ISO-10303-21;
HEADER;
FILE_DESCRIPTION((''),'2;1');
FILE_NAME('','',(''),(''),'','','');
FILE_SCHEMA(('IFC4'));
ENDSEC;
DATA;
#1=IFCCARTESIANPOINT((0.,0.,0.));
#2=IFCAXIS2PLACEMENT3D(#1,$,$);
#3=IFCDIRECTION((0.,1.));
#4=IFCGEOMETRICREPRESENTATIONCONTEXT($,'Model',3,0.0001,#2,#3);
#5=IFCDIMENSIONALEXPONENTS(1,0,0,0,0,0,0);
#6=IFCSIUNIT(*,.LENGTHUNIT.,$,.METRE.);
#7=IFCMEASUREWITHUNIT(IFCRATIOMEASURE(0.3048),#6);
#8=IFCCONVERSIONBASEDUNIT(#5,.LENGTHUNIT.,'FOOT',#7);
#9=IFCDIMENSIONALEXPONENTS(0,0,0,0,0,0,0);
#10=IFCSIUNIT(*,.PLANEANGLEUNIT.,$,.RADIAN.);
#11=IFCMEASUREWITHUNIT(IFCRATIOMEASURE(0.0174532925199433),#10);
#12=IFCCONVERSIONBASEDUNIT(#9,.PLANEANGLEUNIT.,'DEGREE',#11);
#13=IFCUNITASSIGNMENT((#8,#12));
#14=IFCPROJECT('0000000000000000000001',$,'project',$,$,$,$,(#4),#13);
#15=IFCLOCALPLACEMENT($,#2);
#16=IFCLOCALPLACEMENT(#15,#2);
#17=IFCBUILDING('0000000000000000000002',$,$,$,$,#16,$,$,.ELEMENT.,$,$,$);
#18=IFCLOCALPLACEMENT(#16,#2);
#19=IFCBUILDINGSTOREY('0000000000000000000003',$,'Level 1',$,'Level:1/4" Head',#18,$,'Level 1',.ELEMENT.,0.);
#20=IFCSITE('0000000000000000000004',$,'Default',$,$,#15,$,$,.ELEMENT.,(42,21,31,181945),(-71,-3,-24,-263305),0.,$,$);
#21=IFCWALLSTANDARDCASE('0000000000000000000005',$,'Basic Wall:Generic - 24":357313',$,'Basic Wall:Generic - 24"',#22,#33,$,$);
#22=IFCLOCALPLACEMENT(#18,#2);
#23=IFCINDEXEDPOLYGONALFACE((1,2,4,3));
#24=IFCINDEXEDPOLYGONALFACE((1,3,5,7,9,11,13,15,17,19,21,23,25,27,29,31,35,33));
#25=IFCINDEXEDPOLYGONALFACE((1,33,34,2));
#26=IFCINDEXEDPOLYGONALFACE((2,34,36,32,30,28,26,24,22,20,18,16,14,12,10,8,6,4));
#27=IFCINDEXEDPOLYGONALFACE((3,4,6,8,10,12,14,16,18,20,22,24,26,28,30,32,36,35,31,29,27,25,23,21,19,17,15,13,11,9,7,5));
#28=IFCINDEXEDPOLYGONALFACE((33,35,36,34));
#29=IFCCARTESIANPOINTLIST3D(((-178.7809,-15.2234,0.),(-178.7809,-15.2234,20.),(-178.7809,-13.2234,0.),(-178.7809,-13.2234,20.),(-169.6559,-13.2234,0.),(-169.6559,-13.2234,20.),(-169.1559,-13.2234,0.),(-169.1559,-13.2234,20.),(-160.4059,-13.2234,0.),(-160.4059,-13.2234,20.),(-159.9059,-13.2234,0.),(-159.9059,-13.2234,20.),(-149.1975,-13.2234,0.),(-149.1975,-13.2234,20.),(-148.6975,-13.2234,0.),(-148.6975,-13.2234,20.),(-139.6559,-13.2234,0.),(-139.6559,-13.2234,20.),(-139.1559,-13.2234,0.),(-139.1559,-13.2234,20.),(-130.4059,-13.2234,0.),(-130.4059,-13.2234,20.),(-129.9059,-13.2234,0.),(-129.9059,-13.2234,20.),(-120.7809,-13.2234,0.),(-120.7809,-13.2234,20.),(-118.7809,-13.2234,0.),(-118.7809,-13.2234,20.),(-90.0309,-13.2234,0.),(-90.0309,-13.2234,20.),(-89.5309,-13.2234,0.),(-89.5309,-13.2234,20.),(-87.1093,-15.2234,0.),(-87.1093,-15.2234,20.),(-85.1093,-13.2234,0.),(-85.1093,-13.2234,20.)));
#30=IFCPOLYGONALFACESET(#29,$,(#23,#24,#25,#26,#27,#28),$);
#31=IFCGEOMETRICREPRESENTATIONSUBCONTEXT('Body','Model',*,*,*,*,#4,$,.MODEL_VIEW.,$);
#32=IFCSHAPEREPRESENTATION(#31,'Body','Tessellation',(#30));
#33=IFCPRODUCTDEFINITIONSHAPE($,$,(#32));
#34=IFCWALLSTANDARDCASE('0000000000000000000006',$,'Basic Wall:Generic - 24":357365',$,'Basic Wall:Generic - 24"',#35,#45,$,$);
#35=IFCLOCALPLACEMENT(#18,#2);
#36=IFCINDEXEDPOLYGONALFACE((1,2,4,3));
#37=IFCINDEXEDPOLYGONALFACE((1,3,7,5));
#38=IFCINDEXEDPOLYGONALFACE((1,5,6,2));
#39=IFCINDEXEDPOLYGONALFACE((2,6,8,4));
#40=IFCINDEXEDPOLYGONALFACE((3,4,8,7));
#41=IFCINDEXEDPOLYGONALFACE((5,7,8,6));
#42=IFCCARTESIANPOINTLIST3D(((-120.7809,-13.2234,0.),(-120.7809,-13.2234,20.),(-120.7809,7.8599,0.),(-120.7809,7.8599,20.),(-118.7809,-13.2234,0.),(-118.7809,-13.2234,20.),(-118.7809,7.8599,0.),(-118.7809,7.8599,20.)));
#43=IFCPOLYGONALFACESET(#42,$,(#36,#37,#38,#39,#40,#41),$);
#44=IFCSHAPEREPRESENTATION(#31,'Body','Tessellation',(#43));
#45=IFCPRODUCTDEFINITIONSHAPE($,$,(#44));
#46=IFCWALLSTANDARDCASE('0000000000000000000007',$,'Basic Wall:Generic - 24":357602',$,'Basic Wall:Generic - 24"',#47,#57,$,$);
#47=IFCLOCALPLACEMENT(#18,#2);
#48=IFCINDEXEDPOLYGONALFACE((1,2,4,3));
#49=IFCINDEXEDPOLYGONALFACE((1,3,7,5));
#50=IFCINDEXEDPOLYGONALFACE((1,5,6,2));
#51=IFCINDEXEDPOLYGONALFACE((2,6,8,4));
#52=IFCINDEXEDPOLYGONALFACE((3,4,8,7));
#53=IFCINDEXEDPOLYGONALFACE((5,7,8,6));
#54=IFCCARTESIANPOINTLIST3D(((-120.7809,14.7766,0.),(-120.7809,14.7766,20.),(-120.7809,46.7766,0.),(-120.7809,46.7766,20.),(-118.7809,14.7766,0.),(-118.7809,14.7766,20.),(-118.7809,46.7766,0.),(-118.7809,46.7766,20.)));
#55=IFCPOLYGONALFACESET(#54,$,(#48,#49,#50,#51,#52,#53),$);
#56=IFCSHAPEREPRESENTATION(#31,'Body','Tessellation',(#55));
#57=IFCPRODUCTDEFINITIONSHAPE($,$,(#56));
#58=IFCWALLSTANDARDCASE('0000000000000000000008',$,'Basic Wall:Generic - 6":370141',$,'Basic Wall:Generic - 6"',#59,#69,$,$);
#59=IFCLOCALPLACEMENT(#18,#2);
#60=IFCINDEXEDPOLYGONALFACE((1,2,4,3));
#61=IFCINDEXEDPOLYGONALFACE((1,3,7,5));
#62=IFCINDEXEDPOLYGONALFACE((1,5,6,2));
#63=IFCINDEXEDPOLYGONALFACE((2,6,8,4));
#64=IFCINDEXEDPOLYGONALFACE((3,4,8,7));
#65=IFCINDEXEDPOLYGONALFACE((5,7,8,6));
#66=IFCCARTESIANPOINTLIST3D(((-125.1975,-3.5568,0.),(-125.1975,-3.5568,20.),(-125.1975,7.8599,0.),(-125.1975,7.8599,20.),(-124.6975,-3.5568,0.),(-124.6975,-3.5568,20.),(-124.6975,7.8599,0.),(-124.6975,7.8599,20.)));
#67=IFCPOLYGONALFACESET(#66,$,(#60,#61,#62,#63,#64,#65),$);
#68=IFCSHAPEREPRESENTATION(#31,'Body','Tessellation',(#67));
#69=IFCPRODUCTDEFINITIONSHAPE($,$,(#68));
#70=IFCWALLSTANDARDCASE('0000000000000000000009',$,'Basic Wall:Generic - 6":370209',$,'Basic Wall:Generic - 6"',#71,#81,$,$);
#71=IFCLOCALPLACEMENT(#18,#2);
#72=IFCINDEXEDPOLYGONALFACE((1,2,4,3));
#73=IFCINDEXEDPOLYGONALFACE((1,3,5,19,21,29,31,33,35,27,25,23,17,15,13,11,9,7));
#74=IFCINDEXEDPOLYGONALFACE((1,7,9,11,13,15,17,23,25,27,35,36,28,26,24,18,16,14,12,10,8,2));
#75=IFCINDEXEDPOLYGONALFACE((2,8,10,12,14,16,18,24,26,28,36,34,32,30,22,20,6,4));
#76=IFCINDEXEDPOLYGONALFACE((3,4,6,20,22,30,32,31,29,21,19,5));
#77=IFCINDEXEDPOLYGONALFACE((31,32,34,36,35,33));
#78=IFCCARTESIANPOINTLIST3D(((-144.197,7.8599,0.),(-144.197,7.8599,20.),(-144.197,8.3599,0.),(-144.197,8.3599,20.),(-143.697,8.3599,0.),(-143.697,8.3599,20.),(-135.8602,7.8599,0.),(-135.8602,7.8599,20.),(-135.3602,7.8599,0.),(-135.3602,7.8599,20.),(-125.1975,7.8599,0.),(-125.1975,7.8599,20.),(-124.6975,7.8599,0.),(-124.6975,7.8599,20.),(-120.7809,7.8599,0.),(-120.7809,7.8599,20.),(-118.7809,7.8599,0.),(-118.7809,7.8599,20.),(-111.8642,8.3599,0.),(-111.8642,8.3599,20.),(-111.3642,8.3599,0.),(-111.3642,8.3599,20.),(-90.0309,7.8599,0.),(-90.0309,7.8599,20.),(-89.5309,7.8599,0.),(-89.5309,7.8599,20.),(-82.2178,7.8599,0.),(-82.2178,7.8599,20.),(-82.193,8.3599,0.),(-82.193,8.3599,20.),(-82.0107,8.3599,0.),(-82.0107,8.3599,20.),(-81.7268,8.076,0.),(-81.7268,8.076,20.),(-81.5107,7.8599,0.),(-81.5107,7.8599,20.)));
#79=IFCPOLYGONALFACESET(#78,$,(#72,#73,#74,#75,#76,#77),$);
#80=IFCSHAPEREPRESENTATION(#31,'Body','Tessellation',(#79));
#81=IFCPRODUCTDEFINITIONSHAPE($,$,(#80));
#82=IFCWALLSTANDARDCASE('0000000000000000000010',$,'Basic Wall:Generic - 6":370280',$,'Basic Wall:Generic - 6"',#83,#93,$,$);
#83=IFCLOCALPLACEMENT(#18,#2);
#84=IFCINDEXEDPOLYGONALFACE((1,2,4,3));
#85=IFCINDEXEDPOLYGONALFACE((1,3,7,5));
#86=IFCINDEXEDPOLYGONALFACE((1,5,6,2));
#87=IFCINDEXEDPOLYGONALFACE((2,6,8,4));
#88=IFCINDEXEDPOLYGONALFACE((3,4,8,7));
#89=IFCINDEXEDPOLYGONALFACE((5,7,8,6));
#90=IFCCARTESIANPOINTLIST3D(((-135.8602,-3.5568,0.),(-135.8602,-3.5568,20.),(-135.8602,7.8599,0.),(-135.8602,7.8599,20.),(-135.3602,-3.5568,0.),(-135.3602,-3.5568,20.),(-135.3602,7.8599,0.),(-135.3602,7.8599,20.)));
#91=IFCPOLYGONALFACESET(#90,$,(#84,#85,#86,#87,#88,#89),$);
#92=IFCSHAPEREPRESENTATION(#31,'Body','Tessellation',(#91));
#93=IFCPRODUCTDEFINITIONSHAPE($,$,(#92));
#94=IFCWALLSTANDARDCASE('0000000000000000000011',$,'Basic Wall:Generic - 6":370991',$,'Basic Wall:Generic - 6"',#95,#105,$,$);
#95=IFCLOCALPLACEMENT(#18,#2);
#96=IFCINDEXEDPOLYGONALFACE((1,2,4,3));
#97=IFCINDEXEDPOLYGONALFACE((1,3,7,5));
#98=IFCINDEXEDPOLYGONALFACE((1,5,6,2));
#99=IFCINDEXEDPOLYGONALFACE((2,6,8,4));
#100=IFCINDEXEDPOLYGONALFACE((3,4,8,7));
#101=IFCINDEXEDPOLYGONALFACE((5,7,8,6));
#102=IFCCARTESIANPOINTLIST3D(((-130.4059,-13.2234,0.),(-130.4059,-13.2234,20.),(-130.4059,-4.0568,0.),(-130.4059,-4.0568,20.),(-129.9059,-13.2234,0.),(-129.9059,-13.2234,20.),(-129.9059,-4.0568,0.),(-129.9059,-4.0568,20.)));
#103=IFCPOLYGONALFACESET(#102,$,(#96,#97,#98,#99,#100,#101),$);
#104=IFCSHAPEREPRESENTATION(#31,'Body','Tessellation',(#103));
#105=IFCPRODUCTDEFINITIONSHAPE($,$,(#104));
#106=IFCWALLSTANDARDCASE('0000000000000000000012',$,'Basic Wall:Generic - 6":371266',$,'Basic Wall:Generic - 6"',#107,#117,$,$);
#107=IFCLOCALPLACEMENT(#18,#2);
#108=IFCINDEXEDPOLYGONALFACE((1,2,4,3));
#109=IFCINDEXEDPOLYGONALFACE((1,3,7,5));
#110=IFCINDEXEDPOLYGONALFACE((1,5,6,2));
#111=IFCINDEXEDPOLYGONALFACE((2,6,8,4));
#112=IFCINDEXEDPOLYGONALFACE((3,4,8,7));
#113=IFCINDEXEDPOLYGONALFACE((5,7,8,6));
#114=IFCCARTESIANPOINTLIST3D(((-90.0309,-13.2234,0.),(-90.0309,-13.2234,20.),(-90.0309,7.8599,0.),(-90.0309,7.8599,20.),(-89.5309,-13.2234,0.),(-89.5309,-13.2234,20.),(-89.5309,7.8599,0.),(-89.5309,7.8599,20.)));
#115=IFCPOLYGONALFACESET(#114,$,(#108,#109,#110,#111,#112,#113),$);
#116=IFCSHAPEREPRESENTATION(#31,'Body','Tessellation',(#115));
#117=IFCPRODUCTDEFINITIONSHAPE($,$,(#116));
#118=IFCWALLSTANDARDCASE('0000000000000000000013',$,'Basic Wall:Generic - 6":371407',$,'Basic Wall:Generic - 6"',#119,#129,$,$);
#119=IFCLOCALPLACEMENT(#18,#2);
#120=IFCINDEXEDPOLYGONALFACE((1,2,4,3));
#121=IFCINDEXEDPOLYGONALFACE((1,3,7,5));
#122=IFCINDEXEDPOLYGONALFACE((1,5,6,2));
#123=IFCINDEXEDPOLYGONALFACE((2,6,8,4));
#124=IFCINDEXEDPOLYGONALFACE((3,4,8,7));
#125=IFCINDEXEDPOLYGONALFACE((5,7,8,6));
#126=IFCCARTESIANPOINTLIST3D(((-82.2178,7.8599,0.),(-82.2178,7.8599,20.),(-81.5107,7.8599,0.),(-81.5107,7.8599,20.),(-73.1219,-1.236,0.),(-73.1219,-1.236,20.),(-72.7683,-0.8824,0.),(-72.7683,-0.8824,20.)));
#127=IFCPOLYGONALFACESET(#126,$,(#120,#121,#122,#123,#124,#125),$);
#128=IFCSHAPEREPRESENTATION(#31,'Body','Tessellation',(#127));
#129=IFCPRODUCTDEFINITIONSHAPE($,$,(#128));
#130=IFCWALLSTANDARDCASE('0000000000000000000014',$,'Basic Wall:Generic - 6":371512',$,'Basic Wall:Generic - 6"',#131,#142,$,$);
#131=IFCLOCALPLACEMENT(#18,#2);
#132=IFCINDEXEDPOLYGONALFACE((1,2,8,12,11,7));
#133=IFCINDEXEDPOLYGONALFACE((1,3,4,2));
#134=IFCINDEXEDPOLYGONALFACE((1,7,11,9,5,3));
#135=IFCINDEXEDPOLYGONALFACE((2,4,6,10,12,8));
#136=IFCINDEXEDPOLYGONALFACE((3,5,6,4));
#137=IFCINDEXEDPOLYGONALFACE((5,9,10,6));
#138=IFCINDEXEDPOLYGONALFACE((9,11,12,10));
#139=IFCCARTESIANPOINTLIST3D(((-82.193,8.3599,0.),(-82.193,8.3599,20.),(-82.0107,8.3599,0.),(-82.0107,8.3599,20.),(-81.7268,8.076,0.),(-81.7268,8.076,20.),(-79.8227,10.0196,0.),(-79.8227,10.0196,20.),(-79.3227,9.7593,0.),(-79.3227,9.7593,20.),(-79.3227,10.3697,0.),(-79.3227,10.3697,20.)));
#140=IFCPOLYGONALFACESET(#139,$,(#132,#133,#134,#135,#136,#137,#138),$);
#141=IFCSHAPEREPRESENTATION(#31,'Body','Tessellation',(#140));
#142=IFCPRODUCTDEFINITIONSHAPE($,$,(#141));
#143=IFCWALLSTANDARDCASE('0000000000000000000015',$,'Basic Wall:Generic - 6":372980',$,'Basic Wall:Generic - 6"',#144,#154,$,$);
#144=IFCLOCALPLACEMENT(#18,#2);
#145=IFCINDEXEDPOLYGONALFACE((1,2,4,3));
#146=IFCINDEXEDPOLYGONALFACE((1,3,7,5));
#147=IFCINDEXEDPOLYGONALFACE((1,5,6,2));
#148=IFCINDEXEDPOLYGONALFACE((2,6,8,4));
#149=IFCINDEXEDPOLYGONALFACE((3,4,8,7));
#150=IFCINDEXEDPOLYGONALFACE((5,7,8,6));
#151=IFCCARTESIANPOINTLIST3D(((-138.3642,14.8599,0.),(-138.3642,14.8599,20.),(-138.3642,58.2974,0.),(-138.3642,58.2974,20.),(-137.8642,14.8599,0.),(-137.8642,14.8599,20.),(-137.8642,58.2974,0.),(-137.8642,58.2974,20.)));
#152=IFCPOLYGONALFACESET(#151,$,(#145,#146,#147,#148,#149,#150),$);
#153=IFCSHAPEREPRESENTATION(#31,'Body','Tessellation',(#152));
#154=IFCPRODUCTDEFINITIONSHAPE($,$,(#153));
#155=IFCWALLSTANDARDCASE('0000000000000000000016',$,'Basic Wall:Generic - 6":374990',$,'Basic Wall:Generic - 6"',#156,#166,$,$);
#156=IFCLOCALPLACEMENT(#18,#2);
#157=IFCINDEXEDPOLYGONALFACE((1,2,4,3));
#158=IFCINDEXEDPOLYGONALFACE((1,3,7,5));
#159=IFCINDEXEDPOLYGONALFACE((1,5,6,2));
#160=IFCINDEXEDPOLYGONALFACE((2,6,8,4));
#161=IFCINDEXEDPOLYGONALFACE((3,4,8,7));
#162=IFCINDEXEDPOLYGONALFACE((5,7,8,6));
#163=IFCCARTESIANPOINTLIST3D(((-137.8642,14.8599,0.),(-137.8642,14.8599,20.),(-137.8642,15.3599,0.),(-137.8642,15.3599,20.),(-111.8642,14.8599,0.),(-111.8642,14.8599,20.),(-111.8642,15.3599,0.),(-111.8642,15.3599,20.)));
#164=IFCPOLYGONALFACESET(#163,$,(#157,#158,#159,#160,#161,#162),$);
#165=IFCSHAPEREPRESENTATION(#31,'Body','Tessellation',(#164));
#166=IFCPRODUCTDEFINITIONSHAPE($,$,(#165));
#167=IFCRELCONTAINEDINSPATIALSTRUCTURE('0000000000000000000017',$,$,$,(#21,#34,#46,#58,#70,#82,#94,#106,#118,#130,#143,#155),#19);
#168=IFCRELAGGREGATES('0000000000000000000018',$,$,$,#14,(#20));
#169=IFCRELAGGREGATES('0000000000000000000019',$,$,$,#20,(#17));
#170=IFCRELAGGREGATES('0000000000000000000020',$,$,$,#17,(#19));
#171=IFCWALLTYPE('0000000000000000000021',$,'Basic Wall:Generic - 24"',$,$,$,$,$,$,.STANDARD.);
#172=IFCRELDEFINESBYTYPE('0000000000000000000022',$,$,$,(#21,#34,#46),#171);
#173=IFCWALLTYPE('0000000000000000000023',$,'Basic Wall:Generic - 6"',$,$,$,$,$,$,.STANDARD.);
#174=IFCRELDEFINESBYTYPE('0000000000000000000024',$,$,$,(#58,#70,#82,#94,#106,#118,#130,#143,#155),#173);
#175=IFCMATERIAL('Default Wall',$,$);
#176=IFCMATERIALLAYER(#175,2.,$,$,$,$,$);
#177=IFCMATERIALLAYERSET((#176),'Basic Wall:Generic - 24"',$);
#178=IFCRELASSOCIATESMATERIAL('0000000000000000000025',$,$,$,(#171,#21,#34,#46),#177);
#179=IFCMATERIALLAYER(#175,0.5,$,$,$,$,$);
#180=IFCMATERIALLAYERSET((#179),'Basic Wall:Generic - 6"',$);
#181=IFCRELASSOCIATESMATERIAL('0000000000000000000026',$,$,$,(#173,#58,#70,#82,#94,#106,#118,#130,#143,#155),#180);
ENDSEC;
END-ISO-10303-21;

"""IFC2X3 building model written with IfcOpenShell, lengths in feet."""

from ifc_helpers import new_model, entity, si_unit, converted_unit, direction, frame, frame_2d, origin, place, context, subcontext, project, spatial, polyline, rectangle, outline, extrude, material, layer, layer_set, layer_usage, type_object, element, save


model = new_model("IFC2X3")

# Units and contexts
model_context = context("Model", 3, precision=0.0001, world=origin(), true_north=direction((0.0, 1.0)))
body_context = subcontext(model_context, "Body", "Model", "MODEL_VIEW")
ifc_project = project(units=[converted_unit("LENGTHUNIT", "FOOT", entity("IfcRatioMeasure", 0.3048), si_unit("LENGTHUNIT", "METRE"), dimensions=[1, 0, 0, 0, 0, 0, 0]), converted_unit("PLANEANGLEUNIT", "DEGREE", entity("IfcRatioMeasure", 0.0174532925199433), si_unit("PLANEANGLEUNIT", "RADIAN"), dimensions=[0, 0, 0, 0, 0, 0, 0])], contexts=[model_context])

# Site, building, storey
site_placement = place(None, origin())
site = spatial("IfcSite", under=ifc_project, at=site_placement, Name="Default", CompositionType="ELEMENT", RefLatitude=(42, 21, 31, 181945), RefLongitude=(-71, -3, -24, -263305), RefElevation=0.0)
building_placement = place(site_placement, origin())
building = spatial("IfcBuilding", under=site, at=building_placement, CompositionType="ELEMENT")
storey_placement = place(building_placement, origin())
storey = spatial("IfcBuildingStorey", under=building, at=storey_placement, Name="Level 1", ObjectType="Level:1/4\" Head", LongName="Level 1", CompositionType="ELEMENT", Elevation=0.0)

# Walls
ifc_material = material(Name="Default Wall")
ifc_layer_1 = layer(ifc_material, 2.0)
ifc_layer_set_1 = layer_set([ifc_layer_1], Name="Basic Wall:Generic - 24\"")
ifc_layer_usage_1 = layer_usage(ifc_layer_set_1, "AXIS2", "NEGATIVE", 1.0)
wall_type_1 = type_object("IfcWallType", Name="Basic Wall:Generic - 24\"", PredefinedType="STANDARD", material=ifc_layer_set_1)
wall_1_placement = place(storey_placement, frame((-85.1093, -14.2234, 0.0), z_axis=(0.0, 0.0, 1.0), x_axis=(-1.0, 0.0, 0.0)))
element("IfcWallStandardCase", 1, at=wall_1_placement, inside=storey, type_object=wall_type_1, material=ifc_layer_usage_1, Name="Basic Wall:Generic - 24\":357313", ObjectType="Basic Wall:Generic - 24\"", context=body_context, shape_type="SweptSolid", body=[
    extrude(outline(polyline([(93.6716, -1.0), (93.6716, 1.0), (2.0, 1.0), (0.0, -1.0), (4.4216, -1.0), (4.9216, -1.0), (33.6716, -1.0), (35.6716, -1.0), (44.7966, -1.0), (45.2966, -1.0), (54.0466, -1.0), (54.5466, -1.0), (63.5883, -1.0), (64.0883, -1.0), (74.7966, -1.0), (75.2966, -1.0), (84.0466, -1.0), (84.5466, -1.0), (93.6716, -1.0)])), origin(), (0.0, 0.0, 1.0), 20.0),
])
ifc_layer_usage_2 = layer_usage(ifc_layer_set_1, "AXIS2", "NEGATIVE", 1.0)
wall_2_placement = place(storey_placement, frame((-119.7809, -13.2234, 0.0), z_axis=(0.0, 0.0, 1.0), x_axis=(0.0, 1.0, 0.0)))
element("IfcWallStandardCase", 2, at=wall_2_placement, inside=storey, type_object=wall_type_1, material=ifc_layer_usage_2, Name="Basic Wall:Generic - 24\":357365", ObjectType="Basic Wall:Generic - 24\"", context=body_context, shape_type="SweptSolid", body=[
    extrude(rectangle(XDim=21.0833, YDim=2.0, at=frame_2d((10.5417, 0.0), x_axis=(-1.0, 0.0))), origin(), (0.0, 0.0, 1.0), 20.0),
])
ifc_layer_usage_3 = layer_usage(ifc_layer_set_1, "AXIS2", "NEGATIVE", 1.0)
wall_3_placement = place(storey_placement, frame((-119.7809, 14.7766, 0.0), z_axis=(0.0, 0.0, 1.0), x_axis=(0.0, 1.0, 0.0)))
element("IfcWallStandardCase", 3, at=wall_3_placement, inside=storey, type_object=wall_type_1, material=ifc_layer_usage_3, Name="Basic Wall:Generic - 24\":357602", ObjectType="Basic Wall:Generic - 24\"", context=body_context, shape_type="SweptSolid", body=[
    extrude(rectangle(XDim=32.0, YDim=2.0, at=frame_2d((16.0, 0.0), x_axis=(-1.0, 0.0))), origin(), (0.0, 0.0, 1.0), 20.0),
])
ifc_layer_2 = layer(ifc_material, 0.5)
ifc_layer_set_2 = layer_set([ifc_layer_2], Name="Basic Wall:Generic - 6\"")
ifc_layer_usage_4 = layer_usage(ifc_layer_set_2, "AXIS2", "NEGATIVE", 0.25)
wall_type_2 = type_object("IfcWallType", Name="Basic Wall:Generic - 6\"", PredefinedType="STANDARD", material=ifc_layer_set_2)
wall_4_placement = place(storey_placement, frame((-124.9475, -3.5568, 0.0), z_axis=(0.0, 0.0, 1.0), x_axis=(0.0, 1.0, 0.0)))
element("IfcWallStandardCase", 4, at=wall_4_placement, inside=storey, type_object=wall_type_2, material=ifc_layer_usage_4, Name="Basic Wall:Generic - 6\":370141", ObjectType="Basic Wall:Generic - 6\"", context=body_context, shape_type="SweptSolid", body=[
    extrude(rectangle(XDim=11.4167, YDim=0.5, at=frame_2d((5.7083, 0.0), x_axis=(-1.0, 0.0))), origin(), (0.0, 0.0, 1.0), 20.0),
])
ifc_layer_usage_5 = layer_usage(ifc_layer_set_2, "AXIS2", "NEGATIVE", 0.25)
wall_5_placement = place(storey_placement, frame((-81.5107, 8.1099, 0.0), z_axis=(0.0, 0.0, 1.0), x_axis=(-1.0, 0.0, 0.0)))
element("IfcWallStandardCase", 5, at=wall_5_placement, inside=storey, type_object=wall_type_2, material=ifc_layer_usage_5, Name="Basic Wall:Generic - 6\":370209", ObjectType="Basic Wall:Generic - 6\"", context=body_context, shape_type="SweptSolid", body=[
    extrude(outline(polyline([(62.6863, -0.25), (62.6863, 0.25), (54.3496, 0.25), (53.8496, 0.25), (43.6869, 0.25), (43.1869, 0.25), (39.2702, 0.25), (37.2702, 0.25), (8.5202, 0.25), (8.0202, 0.25), (0.7071, 0.25), (0.0, 0.25), (0.2161, 0.0339), (0.5, -0.25), (0.6824, -0.25), (29.8536, -0.25), (30.3536, -0.25), (62.1863, -0.25), (62.6863, -0.25)])), origin(), (0.0, 0.0, 1.0), 20.0),
])
ifc_layer_usage_6 = layer_usage(ifc_layer_set_2, "AXIS2", "NEGATIVE", 0.25)
wall_6_placement = place(storey_placement, frame((-135.6102, 7.8599, 0.0), z_axis=(0.0, 0.0, 1.0), x_axis=(0.0, -1.0, 0.0)))
element("IfcWallStandardCase", 6, at=wall_6_placement, inside=storey, type_object=wall_type_2, material=ifc_layer_usage_6, Name="Basic Wall:Generic - 6\":370280", ObjectType="Basic Wall:Generic - 6\"", context=body_context, shape_type="SweptSolid", body=[
    extrude(rectangle(XDim=11.4167, YDim=0.5, at=frame_2d((5.7083, 0.0), x_axis=(-1.0, 0.0))), origin(), (0.0, 0.0, 1.0), 20.0),
])
ifc_layer_usage_7 = layer_usage(ifc_layer_set_2, "AXIS2", "NEGATIVE", 0.25)
wall_7_placement = place(storey_placement, frame((-130.1559, -4.0568, 0.0), z_axis=(0.0, 0.0, 1.0), x_axis=(0.0, -1.0, 0.0)))
element("IfcWallStandardCase", 7, at=wall_7_placement, inside=storey, type_object=wall_type_2, material=ifc_layer_usage_7, Name="Basic Wall:Generic - 6\":370991", ObjectType="Basic Wall:Generic - 6\"", context=body_context, shape_type="SweptSolid", body=[
    extrude(rectangle(XDim=9.1667, YDim=0.5, at=frame_2d((4.5833, 0.0), x_axis=(-1.0, 0.0))), origin(), (0.0, 0.0, 1.0), 20.0),
])
ifc_layer_usage_8 = layer_usage(ifc_layer_set_2, "AXIS2", "NEGATIVE", 0.25)
wall_8_placement = place(storey_placement, frame((-89.7809, 7.8599, 0.0), z_axis=(0.0, 0.0, 1.0), x_axis=(0.0, -1.0, 0.0)))
element("IfcWallStandardCase", 8, at=wall_8_placement, inside=storey, type_object=wall_type_2, material=ifc_layer_usage_8, Name="Basic Wall:Generic - 6\":371266", ObjectType="Basic Wall:Generic - 6\"", context=body_context, shape_type="SweptSolid", body=[
    extrude(rectangle(XDim=21.0833, YDim=0.5, at=frame_2d((10.5417, 0.0), x_axis=(-1.0, 0.0))), origin(), (0.0, 0.0, 1.0), 20.0),
])
ifc_layer_usage_9 = layer_usage(ifc_layer_set_2, "AXIS2", "NEGATIVE", 0.25)
wall_9_placement = place(storey_placement, frame((-82.041, 8.0367, 0.0), z_axis=(0.0, 0.0, 1.0), x_axis=(0.707107, -0.707107, 0.0)))
element("IfcWallStandardCase", 9, at=wall_9_placement, inside=storey, type_object=wall_type_2, material=ifc_layer_usage_9, Name="Basic Wall:Generic - 6\":371407", ObjectType="Basic Wall:Generic - 6\"", context=body_context, shape_type="SweptSolid", body=[
    extrude(outline(polyline([(12.8636, -0.25), (12.8636, 0.25), (0.5, 0.25), (0.0, -0.25), (12.8636, -0.25)])), origin(), (0.0, 0.0, 1.0), 20.0),
])
ifc_layer_usage_10 = layer_usage(ifc_layer_set_2, "AXIS2", "NEGATIVE", 0.25)
wall_10_placement = place(storey_placement, frame((-82.0496, 8.1551, 0.0), z_axis=(0.0, 0.0, 1.0), x_axis=(0.819152, 0.573576, 0.0)))
element("IfcWallStandardCase", 10, at=wall_10_placement, inside=storey, type_object=wall_type_2, material=ifc_layer_usage_10, Name="Basic Wall:Generic - 6\":371512", ObjectType="Basic Wall:Generic - 6\"", context=body_context, shape_type="SweptSolid", body=[
    extrude(outline(polyline([(3.1539, -0.25), (3.504, 0.25), (2.8936, 0.25), (0.0, 0.25), (0.1494, 0.1454), (0.2191, -0.25), (3.1539, -0.25)])), origin(), (0.0, 0.0, 1.0), 20.0),
])
ifc_layer_usage_11 = layer_usage(ifc_layer_set_2, "AXIS2", "NEGATIVE", 0.25)
wall_11_placement = place(storey_placement, frame((-138.1142, 58.2974, 0.0), z_axis=(0.0, 0.0, 1.0), x_axis=(0.0, -1.0, 0.0)))
element("IfcWallStandardCase", 11, at=wall_11_placement, inside=storey, type_object=wall_type_2, material=ifc_layer_usage_11, Name="Basic Wall:Generic - 6\":372980", ObjectType="Basic Wall:Generic - 6\"", context=body_context, shape_type="SweptSolid", body=[
    extrude(rectangle(XDim=43.4375, YDim=0.5, at=frame_2d((21.7188, 0.0), x_axis=(-1.0, 0.0))), origin(), (0.0, 0.0, 1.0), 20.0),
])
ifc_layer_usage_12 = layer_usage(ifc_layer_set_2, "AXIS2", "NEGATIVE", 0.25)
wall_12_placement = place(storey_placement, frame((-137.8642, 15.1099, 0.0)))
element("IfcWallStandardCase", 12, at=wall_12_placement, inside=storey, type_object=wall_type_2, material=ifc_layer_usage_12, Name="Basic Wall:Generic - 6\":374990", ObjectType="Basic Wall:Generic - 6\"", context=body_context, shape_type="SweptSolid", body=[
    extrude(rectangle(XDim=26.0, YDim=0.5, at=frame_2d((13.0, 0.0), x_axis=(-1.0, 0.0))), origin(), (0.0, 0.0, 1.0), 20.0),
])

save(model, "model.ifc")
